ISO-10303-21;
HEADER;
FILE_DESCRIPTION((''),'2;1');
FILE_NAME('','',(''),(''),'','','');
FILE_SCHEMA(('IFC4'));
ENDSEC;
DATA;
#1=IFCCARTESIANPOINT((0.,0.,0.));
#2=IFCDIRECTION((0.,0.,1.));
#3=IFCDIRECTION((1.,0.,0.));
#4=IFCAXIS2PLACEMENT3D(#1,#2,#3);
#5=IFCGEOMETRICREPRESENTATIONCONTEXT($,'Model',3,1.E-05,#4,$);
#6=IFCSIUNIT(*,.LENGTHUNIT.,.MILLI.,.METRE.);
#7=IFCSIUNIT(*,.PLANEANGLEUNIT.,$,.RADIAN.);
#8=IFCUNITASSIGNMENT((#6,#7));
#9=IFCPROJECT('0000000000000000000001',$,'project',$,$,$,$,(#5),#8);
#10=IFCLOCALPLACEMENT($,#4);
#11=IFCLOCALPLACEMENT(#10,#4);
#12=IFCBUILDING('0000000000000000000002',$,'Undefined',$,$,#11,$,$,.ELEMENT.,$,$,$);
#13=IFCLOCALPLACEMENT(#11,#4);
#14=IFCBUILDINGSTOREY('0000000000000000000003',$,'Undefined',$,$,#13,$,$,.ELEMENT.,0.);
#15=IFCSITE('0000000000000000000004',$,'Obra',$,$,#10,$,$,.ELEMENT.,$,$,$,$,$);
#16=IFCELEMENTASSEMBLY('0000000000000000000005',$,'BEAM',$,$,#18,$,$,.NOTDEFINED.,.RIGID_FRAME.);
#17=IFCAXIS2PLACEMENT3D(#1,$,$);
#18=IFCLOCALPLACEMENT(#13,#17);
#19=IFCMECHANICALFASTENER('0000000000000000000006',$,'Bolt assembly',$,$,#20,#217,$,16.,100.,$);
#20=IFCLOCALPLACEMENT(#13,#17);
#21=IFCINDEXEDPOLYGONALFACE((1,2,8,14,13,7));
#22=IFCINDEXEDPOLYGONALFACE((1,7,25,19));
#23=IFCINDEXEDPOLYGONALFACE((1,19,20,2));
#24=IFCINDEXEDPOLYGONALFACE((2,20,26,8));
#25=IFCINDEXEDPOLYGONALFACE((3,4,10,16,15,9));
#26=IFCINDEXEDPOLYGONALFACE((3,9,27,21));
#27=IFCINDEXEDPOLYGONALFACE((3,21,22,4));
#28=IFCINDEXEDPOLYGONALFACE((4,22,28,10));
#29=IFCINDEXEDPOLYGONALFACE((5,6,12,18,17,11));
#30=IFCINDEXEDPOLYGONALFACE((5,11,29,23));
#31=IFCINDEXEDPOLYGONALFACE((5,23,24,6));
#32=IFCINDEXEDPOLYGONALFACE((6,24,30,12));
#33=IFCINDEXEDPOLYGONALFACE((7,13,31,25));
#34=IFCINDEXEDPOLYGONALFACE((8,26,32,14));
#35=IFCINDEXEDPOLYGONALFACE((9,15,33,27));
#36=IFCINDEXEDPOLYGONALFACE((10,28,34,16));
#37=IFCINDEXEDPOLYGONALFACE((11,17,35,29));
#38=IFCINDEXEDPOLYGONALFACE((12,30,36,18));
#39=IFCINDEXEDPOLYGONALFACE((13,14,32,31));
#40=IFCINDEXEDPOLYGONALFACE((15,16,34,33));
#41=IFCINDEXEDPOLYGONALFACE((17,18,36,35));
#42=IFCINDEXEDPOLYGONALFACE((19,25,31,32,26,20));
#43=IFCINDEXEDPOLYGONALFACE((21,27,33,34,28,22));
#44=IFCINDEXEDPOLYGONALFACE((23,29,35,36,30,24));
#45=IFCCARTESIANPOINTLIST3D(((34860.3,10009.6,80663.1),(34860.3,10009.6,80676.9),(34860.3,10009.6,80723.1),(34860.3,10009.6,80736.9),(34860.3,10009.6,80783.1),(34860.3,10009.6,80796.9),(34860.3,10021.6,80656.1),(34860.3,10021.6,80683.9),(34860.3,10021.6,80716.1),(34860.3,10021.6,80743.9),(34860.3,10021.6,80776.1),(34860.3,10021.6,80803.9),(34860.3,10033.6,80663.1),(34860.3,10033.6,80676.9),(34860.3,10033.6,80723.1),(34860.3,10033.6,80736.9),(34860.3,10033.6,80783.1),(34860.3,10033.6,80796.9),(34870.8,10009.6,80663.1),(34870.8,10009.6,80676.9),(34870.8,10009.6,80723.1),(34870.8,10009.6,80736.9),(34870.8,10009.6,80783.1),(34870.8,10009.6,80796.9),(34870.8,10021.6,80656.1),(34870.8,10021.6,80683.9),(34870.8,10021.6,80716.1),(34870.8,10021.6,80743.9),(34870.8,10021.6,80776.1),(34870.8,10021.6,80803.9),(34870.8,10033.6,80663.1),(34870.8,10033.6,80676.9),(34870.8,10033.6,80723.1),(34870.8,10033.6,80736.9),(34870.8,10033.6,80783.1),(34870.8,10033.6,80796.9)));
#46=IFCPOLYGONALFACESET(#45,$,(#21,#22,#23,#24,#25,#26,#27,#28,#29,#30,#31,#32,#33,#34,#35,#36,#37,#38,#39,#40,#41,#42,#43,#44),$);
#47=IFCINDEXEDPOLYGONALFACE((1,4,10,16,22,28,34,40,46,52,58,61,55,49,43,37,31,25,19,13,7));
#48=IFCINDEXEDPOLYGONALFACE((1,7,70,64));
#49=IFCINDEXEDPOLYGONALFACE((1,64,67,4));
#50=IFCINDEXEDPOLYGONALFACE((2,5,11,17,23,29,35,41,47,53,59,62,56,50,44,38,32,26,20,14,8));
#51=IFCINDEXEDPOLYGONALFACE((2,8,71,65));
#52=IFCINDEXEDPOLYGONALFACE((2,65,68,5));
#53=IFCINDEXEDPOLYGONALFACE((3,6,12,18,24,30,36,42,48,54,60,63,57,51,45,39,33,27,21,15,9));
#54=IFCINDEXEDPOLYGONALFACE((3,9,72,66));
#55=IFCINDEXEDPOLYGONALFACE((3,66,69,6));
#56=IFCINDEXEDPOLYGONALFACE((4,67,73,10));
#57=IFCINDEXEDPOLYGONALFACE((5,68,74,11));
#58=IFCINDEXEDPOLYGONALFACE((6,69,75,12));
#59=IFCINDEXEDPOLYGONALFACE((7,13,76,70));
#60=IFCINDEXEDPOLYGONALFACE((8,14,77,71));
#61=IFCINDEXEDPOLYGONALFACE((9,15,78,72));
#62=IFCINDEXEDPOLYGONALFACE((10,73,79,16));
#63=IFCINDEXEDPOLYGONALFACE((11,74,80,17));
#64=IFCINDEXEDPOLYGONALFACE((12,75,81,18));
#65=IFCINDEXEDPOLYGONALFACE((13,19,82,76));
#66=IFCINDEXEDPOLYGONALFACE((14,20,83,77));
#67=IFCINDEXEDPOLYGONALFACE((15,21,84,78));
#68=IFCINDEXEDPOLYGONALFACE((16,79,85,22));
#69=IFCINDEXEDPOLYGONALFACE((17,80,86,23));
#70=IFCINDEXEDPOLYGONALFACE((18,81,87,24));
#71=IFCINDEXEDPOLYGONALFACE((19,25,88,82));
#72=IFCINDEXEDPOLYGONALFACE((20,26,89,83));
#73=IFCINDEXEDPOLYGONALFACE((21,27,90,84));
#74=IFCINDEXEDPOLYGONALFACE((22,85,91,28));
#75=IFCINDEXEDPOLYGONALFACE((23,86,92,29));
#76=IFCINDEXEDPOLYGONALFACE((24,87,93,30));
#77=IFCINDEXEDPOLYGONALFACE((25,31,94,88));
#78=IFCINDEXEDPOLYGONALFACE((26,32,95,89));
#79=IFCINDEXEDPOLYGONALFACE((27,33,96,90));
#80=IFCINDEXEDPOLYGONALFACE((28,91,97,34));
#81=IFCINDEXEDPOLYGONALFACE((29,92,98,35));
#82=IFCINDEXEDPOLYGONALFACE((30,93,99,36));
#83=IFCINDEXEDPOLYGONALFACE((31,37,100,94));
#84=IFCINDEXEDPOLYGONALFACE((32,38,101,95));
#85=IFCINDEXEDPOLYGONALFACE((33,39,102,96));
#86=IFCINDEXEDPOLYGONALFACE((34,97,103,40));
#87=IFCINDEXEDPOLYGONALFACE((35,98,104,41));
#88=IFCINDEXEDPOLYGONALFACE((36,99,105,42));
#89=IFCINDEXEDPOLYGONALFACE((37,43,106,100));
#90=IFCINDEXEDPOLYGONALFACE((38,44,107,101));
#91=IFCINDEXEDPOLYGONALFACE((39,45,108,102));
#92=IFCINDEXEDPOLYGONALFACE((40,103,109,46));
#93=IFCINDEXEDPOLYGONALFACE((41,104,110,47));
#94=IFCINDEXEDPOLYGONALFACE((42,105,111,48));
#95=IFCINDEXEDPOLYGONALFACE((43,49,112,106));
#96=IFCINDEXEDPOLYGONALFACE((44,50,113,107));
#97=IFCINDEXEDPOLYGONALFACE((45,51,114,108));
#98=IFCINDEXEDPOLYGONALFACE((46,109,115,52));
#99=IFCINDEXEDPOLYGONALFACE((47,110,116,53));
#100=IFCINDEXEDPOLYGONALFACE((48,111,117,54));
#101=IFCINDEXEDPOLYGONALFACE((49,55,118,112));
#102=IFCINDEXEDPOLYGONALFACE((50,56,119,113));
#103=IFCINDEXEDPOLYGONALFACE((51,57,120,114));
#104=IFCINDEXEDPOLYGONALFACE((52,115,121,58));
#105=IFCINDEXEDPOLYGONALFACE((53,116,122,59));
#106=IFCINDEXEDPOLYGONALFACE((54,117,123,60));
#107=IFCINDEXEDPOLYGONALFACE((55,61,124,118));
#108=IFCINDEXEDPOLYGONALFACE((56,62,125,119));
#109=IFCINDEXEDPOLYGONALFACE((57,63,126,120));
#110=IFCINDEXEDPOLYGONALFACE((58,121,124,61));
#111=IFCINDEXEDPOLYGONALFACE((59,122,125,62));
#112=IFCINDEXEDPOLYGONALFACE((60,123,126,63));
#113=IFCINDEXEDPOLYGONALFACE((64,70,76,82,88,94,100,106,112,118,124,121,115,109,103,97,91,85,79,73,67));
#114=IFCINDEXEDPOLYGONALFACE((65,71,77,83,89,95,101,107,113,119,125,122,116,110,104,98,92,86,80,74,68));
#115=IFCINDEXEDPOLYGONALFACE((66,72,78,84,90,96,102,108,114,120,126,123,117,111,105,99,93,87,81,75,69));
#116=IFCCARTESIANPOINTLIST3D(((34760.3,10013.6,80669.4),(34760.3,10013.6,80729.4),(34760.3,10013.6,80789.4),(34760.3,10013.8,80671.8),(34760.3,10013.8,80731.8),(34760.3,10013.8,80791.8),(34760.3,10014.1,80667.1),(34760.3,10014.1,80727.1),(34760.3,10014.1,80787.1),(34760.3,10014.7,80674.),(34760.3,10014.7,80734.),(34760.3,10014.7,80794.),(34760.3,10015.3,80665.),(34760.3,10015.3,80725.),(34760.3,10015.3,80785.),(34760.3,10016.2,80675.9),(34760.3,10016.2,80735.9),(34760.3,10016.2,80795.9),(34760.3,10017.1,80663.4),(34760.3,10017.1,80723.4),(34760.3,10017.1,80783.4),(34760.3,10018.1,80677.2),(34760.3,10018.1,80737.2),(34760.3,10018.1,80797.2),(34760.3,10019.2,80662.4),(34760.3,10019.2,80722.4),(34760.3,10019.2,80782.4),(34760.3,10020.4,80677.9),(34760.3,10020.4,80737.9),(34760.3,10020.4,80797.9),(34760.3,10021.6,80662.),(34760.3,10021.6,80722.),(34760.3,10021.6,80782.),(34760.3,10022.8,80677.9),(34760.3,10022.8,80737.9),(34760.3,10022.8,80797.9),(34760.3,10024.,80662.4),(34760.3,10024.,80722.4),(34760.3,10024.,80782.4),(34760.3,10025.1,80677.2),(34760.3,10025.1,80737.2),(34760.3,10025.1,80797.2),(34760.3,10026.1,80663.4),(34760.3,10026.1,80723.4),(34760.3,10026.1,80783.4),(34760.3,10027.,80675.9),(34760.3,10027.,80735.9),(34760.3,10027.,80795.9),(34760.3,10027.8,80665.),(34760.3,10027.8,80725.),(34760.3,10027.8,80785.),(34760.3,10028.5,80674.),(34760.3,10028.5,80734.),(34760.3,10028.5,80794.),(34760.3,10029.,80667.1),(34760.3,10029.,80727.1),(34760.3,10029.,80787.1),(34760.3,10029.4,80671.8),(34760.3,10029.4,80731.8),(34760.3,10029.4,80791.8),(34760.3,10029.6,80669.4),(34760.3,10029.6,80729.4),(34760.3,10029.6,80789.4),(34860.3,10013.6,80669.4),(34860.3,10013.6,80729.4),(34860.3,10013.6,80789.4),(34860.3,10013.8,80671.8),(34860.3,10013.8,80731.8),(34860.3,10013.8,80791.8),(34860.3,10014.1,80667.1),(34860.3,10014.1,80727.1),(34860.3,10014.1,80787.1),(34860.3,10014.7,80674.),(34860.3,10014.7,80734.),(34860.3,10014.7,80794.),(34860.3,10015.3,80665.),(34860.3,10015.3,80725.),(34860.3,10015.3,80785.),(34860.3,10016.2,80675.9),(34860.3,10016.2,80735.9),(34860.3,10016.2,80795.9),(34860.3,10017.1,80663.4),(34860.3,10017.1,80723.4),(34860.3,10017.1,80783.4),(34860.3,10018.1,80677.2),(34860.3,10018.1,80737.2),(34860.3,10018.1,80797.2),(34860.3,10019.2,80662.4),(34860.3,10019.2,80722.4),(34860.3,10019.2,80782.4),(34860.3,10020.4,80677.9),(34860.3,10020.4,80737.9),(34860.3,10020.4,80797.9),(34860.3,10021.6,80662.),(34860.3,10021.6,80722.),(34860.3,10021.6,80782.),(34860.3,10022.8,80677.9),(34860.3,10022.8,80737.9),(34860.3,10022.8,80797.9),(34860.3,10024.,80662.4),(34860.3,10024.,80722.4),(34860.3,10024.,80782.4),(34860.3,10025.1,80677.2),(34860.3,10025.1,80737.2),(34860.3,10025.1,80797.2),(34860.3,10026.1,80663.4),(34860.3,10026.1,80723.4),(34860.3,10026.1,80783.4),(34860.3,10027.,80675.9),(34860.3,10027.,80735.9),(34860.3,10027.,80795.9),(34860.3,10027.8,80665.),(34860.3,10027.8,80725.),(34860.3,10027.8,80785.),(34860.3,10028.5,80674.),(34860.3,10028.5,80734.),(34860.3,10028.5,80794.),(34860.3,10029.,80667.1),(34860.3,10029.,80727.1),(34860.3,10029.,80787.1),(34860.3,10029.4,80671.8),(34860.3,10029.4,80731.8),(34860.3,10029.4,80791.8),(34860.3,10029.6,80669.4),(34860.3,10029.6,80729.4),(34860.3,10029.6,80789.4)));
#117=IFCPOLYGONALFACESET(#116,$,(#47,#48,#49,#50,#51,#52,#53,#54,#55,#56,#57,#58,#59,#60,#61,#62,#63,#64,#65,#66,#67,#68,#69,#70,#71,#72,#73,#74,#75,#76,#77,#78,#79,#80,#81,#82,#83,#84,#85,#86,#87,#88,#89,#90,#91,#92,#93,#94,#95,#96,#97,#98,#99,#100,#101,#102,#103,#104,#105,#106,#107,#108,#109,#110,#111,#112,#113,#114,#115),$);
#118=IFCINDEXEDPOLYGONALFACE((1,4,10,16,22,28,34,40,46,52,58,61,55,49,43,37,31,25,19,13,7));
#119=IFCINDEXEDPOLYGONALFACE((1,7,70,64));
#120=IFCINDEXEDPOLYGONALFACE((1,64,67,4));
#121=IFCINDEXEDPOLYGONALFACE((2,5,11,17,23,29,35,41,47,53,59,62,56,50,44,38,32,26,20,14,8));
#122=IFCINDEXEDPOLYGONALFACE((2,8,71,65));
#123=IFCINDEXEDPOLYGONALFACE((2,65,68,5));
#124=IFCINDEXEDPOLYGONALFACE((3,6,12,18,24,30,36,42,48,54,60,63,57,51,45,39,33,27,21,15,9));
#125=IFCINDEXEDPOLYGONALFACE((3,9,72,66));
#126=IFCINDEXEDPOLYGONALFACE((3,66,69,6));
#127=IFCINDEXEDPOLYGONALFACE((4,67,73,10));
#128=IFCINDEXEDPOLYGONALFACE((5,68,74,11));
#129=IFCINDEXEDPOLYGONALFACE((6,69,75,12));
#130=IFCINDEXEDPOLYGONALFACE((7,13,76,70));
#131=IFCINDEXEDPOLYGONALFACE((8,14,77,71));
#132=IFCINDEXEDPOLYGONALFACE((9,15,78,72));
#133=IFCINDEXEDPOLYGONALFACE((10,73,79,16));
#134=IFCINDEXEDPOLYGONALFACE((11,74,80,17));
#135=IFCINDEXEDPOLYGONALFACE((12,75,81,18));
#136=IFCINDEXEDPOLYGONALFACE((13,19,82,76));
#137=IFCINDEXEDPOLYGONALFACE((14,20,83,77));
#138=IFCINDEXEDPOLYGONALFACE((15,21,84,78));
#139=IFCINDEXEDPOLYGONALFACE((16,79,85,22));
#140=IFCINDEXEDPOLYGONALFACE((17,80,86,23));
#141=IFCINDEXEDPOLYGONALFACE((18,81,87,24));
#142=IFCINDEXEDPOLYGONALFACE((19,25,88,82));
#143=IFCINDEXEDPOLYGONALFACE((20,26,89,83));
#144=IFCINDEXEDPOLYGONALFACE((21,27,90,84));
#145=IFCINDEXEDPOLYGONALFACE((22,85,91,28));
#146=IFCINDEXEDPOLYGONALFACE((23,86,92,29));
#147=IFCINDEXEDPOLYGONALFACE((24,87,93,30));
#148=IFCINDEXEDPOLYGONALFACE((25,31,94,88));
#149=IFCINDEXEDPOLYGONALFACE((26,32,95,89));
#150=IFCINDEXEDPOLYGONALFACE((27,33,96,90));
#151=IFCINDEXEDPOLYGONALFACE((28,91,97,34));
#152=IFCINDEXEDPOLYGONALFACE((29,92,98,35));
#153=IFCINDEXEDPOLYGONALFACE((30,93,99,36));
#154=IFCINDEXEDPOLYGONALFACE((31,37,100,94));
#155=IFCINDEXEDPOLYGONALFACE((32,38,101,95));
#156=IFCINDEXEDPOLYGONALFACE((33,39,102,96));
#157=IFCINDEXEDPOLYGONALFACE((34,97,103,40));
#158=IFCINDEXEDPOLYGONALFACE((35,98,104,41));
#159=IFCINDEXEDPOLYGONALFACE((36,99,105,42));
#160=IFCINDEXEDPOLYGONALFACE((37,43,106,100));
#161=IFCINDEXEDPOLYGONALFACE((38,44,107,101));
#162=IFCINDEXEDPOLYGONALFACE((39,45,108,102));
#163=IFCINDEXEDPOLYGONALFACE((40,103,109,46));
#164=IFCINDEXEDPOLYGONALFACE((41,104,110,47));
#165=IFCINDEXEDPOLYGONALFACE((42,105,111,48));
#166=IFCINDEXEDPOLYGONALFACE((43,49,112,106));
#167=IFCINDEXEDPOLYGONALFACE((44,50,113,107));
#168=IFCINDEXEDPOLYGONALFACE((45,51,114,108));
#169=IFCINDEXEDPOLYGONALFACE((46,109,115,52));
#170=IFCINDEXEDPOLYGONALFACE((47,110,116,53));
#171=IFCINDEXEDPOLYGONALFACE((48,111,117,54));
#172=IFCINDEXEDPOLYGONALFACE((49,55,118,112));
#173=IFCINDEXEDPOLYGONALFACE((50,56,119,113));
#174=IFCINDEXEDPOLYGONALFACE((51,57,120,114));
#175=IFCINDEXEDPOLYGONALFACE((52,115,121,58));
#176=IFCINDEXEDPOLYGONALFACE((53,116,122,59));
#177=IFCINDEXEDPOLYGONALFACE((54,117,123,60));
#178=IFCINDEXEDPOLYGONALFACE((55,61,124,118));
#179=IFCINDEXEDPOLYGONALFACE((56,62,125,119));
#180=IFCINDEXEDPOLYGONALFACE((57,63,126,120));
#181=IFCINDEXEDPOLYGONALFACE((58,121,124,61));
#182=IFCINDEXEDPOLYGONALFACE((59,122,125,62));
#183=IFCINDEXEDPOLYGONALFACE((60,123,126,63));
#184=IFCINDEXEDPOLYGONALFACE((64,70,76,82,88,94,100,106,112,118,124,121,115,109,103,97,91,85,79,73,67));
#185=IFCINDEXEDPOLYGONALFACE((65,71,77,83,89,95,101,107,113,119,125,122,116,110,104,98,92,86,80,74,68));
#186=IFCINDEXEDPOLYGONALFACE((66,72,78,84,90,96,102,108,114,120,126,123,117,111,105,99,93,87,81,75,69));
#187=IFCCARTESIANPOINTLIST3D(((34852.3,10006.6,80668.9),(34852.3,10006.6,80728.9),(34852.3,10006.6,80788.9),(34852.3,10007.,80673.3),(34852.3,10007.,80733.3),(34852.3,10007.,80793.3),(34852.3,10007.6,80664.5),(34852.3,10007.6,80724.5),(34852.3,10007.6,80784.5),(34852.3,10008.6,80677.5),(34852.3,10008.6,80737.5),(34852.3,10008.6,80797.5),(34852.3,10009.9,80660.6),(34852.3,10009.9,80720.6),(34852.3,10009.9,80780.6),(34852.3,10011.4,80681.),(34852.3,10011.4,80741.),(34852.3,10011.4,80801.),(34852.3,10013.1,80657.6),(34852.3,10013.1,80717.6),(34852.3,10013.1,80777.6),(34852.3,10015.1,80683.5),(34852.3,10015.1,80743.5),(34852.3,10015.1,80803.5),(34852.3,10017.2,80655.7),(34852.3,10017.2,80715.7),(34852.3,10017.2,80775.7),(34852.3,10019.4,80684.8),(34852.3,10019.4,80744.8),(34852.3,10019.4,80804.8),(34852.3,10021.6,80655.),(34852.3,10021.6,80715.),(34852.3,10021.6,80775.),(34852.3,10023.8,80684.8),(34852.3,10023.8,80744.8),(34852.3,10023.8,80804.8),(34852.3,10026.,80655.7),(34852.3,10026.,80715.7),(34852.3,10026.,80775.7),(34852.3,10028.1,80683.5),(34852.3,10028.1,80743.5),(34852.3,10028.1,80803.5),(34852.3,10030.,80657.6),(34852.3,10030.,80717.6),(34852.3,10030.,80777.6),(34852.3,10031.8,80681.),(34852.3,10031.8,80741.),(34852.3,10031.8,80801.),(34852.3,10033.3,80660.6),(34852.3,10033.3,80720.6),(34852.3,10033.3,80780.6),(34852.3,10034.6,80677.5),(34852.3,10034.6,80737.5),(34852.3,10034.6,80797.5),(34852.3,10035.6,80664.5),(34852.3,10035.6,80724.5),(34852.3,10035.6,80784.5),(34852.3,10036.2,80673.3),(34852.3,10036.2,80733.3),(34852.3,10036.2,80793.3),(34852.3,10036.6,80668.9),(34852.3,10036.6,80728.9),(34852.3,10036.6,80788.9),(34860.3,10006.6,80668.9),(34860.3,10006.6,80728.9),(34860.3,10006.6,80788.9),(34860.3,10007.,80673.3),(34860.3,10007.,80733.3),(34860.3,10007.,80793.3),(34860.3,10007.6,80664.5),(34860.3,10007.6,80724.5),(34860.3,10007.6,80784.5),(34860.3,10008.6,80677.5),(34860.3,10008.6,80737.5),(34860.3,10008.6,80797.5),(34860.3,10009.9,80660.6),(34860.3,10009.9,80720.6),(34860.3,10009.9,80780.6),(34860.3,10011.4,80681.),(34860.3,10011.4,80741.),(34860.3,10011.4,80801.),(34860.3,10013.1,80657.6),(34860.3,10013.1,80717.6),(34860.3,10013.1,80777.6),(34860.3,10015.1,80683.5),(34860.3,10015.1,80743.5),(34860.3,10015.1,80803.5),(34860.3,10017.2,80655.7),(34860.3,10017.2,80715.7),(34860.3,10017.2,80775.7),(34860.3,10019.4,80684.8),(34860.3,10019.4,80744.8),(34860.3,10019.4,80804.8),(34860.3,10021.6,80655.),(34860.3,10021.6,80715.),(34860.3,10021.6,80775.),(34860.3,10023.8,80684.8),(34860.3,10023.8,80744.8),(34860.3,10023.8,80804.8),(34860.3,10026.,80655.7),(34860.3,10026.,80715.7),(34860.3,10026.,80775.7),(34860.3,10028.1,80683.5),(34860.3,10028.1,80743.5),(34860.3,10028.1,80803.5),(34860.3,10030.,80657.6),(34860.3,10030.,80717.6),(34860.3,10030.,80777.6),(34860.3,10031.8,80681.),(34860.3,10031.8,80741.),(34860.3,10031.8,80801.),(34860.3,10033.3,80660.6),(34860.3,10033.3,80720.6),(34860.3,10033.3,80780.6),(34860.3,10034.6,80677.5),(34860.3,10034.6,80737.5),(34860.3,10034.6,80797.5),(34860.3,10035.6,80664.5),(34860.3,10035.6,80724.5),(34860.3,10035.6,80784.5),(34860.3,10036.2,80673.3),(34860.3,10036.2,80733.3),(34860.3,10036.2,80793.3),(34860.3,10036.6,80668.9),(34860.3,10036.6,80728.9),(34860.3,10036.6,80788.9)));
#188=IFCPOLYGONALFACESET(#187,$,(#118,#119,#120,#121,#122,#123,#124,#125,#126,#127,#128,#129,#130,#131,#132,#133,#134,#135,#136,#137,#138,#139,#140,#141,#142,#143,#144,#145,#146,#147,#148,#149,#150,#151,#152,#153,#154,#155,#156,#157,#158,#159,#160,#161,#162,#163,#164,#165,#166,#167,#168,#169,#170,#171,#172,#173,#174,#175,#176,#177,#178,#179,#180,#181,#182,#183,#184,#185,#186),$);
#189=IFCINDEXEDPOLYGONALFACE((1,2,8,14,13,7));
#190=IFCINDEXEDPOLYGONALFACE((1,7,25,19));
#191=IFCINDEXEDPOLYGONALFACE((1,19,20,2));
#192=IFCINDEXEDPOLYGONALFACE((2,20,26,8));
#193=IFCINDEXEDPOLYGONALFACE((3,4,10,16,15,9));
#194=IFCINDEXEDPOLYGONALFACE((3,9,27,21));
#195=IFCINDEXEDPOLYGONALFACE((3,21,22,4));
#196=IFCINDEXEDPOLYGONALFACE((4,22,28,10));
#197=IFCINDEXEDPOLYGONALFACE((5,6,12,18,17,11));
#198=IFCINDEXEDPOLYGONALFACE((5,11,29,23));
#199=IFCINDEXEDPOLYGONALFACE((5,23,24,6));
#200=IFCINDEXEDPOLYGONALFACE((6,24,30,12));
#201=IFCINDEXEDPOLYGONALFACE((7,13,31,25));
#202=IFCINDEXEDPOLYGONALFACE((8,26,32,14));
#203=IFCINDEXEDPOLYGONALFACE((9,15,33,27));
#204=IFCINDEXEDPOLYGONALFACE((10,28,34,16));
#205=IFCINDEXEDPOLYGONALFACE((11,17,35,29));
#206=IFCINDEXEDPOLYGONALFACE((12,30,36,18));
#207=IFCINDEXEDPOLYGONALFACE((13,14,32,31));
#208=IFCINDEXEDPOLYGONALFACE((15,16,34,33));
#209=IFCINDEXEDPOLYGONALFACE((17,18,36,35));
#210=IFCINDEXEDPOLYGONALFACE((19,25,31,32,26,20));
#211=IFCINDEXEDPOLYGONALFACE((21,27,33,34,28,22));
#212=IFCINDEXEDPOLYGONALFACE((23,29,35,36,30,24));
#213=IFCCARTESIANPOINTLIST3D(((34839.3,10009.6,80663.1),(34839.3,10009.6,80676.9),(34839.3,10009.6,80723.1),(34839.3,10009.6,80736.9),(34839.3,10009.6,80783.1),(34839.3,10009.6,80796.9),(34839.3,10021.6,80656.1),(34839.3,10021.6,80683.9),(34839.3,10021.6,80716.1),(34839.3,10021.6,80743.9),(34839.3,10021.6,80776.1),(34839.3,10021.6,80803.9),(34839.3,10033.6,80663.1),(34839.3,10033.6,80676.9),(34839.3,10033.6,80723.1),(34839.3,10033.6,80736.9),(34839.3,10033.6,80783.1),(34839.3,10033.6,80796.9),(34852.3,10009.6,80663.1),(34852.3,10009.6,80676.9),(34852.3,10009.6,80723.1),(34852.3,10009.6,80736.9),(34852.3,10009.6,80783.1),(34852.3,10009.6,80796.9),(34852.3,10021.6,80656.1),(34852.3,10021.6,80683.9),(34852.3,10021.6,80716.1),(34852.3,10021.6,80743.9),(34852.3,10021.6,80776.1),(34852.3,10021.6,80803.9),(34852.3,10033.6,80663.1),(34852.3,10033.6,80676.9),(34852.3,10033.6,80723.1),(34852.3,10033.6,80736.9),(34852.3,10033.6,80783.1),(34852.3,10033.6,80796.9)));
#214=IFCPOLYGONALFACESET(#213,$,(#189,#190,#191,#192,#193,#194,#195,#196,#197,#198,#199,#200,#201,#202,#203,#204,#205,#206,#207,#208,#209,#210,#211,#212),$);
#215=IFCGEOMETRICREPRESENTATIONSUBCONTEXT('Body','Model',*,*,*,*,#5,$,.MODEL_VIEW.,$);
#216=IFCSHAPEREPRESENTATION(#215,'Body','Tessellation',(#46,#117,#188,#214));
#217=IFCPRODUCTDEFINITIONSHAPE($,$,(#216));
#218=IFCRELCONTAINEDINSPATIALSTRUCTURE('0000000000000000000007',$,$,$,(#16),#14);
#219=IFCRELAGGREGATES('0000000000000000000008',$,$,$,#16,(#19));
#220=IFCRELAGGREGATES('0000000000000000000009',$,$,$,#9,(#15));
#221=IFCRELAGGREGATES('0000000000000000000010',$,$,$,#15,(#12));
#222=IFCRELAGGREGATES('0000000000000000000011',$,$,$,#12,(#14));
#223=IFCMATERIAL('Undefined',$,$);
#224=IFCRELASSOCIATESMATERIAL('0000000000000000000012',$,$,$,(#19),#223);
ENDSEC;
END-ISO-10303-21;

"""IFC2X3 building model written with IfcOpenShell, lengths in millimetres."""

from ifc_helpers import new_model, si_unit, frame, origin_with_axes, origin_2d_with_axis, place, context, subcontext, project, spatial, polyline, circle, outline, extrude, source, transform, mapped, material, element, aggregate, save


model = new_model("IFC2X3")

# Units and contexts
model_context = context("Model", 3, precision=1e-05, world=origin_with_axes())
body_context = subcontext(model_context, "Body", "Model", "MODEL_VIEW")
ifc_project = project(units=[si_unit("LENGTHUNIT", "METRE", prefix="MILLI"), si_unit("PLANEANGLEUNIT", "RADIAN")], contexts=[model_context])

# Site, building, storey
site_placement = place(None, origin_with_axes())
site = spatial("IfcSite", under=ifc_project, at=site_placement, Name="Obra", CompositionType="ELEMENT")
building_placement = place(site_placement, origin_with_axes())
building = spatial("IfcBuilding", under=site, at=building_placement, Name="Undefined", CompositionType="ELEMENT")
storey_placement = place(building_placement, origin_with_axes())
storey = spatial("IfcBuildingStorey", under=building, at=storey_placement, Name="Undefined", CompositionType="ELEMENT", Elevation=0.0)

# Shared definitions
ifc_material_1 = material(Name="Undefined")

# Element assembly, mechanical fastener
assembly_1_placement = place(storey_placement, origin_with_axes())
assembly_1 = element("IfcElementAssembly", 1, at=assembly_1_placement, inside=storey, Name="BEAM", AssemblyPlace="NOTDEFINED", PredefinedType="RIGID_FRAME")
shared_shape_1 = source(origin_with_axes(), body_context, "Body", "SweptSolid", [
    extrude(outline(polyline([(13.9, 0.0), (6.9, 12.0), (-6.9, 12.0), (-13.9, 0.0), (-6.9, -12.0), (6.9, -12.0), (13.9, 0.0)])), frame((0.0, -10.6, 0.0), z_axis=(0.0, 1.0, 0.0), x_axis=(1.0, 0.0, 0.0)), (0.0, 0.0, 1.0), 10.6),
    extrude(circle(Radius=8.0, at=origin_2d_with_axis()), frame((0.0, 0.0, 0.0), z_axis=(0.0, 1.0, 0.0), x_axis=(1.0, 0.0, 0.0)), (0.0, 0.0, 1.0), 100.0),
    extrude(circle(Radius=15.0, at=origin_2d_with_axis()), frame((0.0, 0.0, 0.0), z_axis=(0.0, 1.0, 0.0), x_axis=(1.0, 0.0, 0.0)), (0.0, 0.0, 1.0), 8.0),
    extrude(outline(polyline([(13.9, 0.0), (6.9, 12.0), (-6.9, 12.0), (-13.9, 0.0), (-6.9, -12.0), (6.9, -12.0), (13.9, 0.0)])), frame((0.0, 8.0, 0.0), z_axis=(0.0, 1.0, 0.0), x_axis=(1.0, 0.0, 0.0)), (0.0, 0.0, 1.0), 13.0),
])
mechanical_fastener_1_placement = place(assembly_1_placement, frame((34860.3, 9971.6, 80850.0), z_axis=(0.0, 1.0, 0.0), x_axis=(0.0, 0.0, -1.0)))
mechanical_fastener_1 = element("IfcMechanicalFastener", 2, at=mechanical_fastener_1_placement, material=ifc_material_1, Name="Bolt assembly", NominalDiameter=16.0, NominalLength=100.0, context=body_context, shape_type="MappedRepresentation", body=[
    mapped(shared_shape_1, transform((60.0, 0.0, 50.0))),
    mapped(shared_shape_1, transform((120.0, 0.0, 50.0))),
    mapped(shared_shape_1, transform((180.0, 0.0, 50.0))),
])
aggregate(assembly_1, [mechanical_fastener_1])

save(model, "model.ifc")
